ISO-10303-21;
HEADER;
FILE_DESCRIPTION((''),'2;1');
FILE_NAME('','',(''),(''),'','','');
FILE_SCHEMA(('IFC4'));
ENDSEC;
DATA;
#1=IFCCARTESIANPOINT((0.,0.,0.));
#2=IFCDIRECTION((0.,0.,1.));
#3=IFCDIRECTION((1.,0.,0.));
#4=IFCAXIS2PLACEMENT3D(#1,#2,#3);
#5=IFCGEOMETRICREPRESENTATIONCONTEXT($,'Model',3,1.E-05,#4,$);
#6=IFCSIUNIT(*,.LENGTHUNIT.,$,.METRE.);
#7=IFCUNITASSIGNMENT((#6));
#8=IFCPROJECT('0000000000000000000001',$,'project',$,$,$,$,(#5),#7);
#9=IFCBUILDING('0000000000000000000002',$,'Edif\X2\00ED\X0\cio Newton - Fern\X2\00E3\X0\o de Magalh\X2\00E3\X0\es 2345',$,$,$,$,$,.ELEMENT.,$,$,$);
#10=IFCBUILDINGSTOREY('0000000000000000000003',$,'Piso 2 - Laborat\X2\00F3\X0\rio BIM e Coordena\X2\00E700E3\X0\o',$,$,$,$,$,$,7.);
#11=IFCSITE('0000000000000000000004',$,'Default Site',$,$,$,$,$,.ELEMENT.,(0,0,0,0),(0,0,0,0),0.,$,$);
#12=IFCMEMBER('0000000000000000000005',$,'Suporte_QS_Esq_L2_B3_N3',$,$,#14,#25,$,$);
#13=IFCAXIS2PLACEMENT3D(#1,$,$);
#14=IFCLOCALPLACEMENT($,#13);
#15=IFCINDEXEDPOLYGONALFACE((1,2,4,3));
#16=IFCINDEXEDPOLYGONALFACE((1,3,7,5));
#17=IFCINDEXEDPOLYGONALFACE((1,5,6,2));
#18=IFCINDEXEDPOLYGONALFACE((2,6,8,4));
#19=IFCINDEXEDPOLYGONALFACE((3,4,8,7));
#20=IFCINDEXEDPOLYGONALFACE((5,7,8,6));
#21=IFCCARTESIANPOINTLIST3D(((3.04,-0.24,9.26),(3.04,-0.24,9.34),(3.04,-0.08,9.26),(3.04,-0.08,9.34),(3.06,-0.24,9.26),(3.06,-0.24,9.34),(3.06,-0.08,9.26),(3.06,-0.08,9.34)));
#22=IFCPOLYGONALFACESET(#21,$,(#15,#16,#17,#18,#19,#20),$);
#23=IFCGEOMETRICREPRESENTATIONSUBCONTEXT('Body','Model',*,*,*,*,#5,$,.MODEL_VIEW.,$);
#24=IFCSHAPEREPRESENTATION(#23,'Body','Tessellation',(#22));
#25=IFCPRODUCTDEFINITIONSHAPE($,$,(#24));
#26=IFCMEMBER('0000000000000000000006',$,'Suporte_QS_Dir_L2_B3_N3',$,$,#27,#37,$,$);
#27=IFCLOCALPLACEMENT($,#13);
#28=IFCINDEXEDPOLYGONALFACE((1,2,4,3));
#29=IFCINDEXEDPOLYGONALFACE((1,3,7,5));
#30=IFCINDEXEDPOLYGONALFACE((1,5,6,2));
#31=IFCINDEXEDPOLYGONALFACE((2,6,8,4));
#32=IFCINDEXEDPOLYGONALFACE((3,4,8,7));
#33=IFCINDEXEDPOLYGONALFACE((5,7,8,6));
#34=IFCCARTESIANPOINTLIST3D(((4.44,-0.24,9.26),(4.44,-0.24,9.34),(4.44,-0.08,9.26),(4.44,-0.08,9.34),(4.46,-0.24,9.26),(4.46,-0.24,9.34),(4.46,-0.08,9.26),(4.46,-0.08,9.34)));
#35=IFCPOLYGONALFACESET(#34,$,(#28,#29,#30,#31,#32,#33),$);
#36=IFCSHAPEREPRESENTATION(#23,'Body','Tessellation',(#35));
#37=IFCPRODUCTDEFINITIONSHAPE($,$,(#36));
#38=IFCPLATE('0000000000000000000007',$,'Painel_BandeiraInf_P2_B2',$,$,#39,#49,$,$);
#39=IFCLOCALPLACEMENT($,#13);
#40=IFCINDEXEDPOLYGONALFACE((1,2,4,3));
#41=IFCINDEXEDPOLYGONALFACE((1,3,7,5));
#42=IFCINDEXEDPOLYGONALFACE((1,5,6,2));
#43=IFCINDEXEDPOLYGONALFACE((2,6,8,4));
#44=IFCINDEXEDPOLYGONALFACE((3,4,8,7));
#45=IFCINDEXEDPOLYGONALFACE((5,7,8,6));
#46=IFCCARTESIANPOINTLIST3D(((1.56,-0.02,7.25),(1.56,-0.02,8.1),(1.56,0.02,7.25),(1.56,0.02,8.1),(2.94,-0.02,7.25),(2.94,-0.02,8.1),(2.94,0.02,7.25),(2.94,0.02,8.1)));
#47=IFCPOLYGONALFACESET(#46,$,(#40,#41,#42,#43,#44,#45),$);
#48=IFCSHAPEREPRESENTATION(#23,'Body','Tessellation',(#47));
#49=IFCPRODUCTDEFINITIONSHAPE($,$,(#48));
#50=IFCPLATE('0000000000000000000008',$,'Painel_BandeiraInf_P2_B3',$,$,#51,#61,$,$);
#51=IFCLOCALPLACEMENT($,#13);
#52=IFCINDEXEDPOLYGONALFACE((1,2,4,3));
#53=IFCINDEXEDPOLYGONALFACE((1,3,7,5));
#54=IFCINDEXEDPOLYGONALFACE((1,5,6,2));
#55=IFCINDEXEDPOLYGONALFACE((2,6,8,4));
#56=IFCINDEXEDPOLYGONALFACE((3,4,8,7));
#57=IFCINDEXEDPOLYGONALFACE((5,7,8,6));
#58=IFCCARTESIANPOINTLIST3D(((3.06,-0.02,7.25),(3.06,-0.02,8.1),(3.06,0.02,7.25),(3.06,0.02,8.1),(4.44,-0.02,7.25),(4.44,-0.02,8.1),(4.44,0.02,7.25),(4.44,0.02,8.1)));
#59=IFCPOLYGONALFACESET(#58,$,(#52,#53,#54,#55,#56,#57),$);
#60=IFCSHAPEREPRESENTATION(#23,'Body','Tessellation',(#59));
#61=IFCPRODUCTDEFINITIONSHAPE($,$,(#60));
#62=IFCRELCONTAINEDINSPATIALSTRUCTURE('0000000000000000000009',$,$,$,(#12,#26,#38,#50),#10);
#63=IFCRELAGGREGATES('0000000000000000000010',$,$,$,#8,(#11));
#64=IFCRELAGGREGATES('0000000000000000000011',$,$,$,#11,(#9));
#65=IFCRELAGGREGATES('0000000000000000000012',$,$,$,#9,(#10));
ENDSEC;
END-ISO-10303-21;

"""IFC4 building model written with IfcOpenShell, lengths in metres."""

from ifc_helpers import new_model, si_unit, frame, frame_2d, origin_with_axes, place, context, subcontext, project, spatial, rectangle, extrude, element, save


model = new_model("IFC4")

# Units and contexts
model_context = context("Model", 3, precision=1e-05, world=origin_with_axes())
body_context = subcontext(model_context, "Body", "Model", "MODEL_VIEW")
ifc_project = project(units=[si_unit("LENGTHUNIT", "METRE")], contexts=[model_context])

# Site, building, storey
site = spatial("IfcSite", under=ifc_project, Name="Default Site", CompositionType="ELEMENT", RefLatitude=(0, 0, 0, 0), RefLongitude=(0, 0, 0, 0), RefElevation=0.0)
building = spatial("IfcBuilding", under=site, Name="Edifício Newton - Fernão de Magalhães 2345", CompositionType="ELEMENT")
storey = spatial("IfcBuildingStorey", under=building, Name="Piso 2 - Laboratório BIM e Coordenação", Elevation=7.0)

# Members
for number, where, z_axis, x_axis, name in (
    (1, (3.04, -0.24, 9.26), (0.0, 0.0, 1.0), (1.0, 0.0, 0.0), "Suporte_QS_Esq_L2_B3_N3"),
    (2, (4.44, -0.24, 9.26), (0.0, 0.0, 1.0), (1.0, 0.0, 0.0), "Suporte_QS_Dir_L2_B3_N3"),
):
    element("IfcMember", number, at=place(None, frame(where, z_axis=z_axis, x_axis=x_axis)), inside=storey, Name=name, context=body_context, shape_type="SweptSolid", body=[
        extrude(rectangle(XDim=0.02, YDim=0.16, at=frame_2d((0.01, 0.08))), origin_with_axes(), (0.0, 0.0, 1.0), 0.08),
    ])

# Plates
for number, where, z_axis, x_axis, name in (
    (3, (1.56, -0.02, 7.25), (0.0, 0.0, 1.0), (1.0, 0.0, 0.0), "Painel_BandeiraInf_P2_B2"),
    (4, (3.06, -0.02, 7.25), (0.0, 0.0, 1.0), (1.0, 0.0, 0.0), "Painel_BandeiraInf_P2_B3"),
):
    element("IfcPlate", number, at=place(None, frame(where, z_axis=z_axis, x_axis=x_axis)), inside=storey, Name=name, context=body_context, shape_type="SweptSolid", body=[
        extrude(rectangle(XDim=1.38, YDim=0.04, at=frame_2d((0.69, 0.02))), origin_with_axes(), (0.0, 0.0, 1.0), 0.85),
    ])

save(model, "model.ifc")
